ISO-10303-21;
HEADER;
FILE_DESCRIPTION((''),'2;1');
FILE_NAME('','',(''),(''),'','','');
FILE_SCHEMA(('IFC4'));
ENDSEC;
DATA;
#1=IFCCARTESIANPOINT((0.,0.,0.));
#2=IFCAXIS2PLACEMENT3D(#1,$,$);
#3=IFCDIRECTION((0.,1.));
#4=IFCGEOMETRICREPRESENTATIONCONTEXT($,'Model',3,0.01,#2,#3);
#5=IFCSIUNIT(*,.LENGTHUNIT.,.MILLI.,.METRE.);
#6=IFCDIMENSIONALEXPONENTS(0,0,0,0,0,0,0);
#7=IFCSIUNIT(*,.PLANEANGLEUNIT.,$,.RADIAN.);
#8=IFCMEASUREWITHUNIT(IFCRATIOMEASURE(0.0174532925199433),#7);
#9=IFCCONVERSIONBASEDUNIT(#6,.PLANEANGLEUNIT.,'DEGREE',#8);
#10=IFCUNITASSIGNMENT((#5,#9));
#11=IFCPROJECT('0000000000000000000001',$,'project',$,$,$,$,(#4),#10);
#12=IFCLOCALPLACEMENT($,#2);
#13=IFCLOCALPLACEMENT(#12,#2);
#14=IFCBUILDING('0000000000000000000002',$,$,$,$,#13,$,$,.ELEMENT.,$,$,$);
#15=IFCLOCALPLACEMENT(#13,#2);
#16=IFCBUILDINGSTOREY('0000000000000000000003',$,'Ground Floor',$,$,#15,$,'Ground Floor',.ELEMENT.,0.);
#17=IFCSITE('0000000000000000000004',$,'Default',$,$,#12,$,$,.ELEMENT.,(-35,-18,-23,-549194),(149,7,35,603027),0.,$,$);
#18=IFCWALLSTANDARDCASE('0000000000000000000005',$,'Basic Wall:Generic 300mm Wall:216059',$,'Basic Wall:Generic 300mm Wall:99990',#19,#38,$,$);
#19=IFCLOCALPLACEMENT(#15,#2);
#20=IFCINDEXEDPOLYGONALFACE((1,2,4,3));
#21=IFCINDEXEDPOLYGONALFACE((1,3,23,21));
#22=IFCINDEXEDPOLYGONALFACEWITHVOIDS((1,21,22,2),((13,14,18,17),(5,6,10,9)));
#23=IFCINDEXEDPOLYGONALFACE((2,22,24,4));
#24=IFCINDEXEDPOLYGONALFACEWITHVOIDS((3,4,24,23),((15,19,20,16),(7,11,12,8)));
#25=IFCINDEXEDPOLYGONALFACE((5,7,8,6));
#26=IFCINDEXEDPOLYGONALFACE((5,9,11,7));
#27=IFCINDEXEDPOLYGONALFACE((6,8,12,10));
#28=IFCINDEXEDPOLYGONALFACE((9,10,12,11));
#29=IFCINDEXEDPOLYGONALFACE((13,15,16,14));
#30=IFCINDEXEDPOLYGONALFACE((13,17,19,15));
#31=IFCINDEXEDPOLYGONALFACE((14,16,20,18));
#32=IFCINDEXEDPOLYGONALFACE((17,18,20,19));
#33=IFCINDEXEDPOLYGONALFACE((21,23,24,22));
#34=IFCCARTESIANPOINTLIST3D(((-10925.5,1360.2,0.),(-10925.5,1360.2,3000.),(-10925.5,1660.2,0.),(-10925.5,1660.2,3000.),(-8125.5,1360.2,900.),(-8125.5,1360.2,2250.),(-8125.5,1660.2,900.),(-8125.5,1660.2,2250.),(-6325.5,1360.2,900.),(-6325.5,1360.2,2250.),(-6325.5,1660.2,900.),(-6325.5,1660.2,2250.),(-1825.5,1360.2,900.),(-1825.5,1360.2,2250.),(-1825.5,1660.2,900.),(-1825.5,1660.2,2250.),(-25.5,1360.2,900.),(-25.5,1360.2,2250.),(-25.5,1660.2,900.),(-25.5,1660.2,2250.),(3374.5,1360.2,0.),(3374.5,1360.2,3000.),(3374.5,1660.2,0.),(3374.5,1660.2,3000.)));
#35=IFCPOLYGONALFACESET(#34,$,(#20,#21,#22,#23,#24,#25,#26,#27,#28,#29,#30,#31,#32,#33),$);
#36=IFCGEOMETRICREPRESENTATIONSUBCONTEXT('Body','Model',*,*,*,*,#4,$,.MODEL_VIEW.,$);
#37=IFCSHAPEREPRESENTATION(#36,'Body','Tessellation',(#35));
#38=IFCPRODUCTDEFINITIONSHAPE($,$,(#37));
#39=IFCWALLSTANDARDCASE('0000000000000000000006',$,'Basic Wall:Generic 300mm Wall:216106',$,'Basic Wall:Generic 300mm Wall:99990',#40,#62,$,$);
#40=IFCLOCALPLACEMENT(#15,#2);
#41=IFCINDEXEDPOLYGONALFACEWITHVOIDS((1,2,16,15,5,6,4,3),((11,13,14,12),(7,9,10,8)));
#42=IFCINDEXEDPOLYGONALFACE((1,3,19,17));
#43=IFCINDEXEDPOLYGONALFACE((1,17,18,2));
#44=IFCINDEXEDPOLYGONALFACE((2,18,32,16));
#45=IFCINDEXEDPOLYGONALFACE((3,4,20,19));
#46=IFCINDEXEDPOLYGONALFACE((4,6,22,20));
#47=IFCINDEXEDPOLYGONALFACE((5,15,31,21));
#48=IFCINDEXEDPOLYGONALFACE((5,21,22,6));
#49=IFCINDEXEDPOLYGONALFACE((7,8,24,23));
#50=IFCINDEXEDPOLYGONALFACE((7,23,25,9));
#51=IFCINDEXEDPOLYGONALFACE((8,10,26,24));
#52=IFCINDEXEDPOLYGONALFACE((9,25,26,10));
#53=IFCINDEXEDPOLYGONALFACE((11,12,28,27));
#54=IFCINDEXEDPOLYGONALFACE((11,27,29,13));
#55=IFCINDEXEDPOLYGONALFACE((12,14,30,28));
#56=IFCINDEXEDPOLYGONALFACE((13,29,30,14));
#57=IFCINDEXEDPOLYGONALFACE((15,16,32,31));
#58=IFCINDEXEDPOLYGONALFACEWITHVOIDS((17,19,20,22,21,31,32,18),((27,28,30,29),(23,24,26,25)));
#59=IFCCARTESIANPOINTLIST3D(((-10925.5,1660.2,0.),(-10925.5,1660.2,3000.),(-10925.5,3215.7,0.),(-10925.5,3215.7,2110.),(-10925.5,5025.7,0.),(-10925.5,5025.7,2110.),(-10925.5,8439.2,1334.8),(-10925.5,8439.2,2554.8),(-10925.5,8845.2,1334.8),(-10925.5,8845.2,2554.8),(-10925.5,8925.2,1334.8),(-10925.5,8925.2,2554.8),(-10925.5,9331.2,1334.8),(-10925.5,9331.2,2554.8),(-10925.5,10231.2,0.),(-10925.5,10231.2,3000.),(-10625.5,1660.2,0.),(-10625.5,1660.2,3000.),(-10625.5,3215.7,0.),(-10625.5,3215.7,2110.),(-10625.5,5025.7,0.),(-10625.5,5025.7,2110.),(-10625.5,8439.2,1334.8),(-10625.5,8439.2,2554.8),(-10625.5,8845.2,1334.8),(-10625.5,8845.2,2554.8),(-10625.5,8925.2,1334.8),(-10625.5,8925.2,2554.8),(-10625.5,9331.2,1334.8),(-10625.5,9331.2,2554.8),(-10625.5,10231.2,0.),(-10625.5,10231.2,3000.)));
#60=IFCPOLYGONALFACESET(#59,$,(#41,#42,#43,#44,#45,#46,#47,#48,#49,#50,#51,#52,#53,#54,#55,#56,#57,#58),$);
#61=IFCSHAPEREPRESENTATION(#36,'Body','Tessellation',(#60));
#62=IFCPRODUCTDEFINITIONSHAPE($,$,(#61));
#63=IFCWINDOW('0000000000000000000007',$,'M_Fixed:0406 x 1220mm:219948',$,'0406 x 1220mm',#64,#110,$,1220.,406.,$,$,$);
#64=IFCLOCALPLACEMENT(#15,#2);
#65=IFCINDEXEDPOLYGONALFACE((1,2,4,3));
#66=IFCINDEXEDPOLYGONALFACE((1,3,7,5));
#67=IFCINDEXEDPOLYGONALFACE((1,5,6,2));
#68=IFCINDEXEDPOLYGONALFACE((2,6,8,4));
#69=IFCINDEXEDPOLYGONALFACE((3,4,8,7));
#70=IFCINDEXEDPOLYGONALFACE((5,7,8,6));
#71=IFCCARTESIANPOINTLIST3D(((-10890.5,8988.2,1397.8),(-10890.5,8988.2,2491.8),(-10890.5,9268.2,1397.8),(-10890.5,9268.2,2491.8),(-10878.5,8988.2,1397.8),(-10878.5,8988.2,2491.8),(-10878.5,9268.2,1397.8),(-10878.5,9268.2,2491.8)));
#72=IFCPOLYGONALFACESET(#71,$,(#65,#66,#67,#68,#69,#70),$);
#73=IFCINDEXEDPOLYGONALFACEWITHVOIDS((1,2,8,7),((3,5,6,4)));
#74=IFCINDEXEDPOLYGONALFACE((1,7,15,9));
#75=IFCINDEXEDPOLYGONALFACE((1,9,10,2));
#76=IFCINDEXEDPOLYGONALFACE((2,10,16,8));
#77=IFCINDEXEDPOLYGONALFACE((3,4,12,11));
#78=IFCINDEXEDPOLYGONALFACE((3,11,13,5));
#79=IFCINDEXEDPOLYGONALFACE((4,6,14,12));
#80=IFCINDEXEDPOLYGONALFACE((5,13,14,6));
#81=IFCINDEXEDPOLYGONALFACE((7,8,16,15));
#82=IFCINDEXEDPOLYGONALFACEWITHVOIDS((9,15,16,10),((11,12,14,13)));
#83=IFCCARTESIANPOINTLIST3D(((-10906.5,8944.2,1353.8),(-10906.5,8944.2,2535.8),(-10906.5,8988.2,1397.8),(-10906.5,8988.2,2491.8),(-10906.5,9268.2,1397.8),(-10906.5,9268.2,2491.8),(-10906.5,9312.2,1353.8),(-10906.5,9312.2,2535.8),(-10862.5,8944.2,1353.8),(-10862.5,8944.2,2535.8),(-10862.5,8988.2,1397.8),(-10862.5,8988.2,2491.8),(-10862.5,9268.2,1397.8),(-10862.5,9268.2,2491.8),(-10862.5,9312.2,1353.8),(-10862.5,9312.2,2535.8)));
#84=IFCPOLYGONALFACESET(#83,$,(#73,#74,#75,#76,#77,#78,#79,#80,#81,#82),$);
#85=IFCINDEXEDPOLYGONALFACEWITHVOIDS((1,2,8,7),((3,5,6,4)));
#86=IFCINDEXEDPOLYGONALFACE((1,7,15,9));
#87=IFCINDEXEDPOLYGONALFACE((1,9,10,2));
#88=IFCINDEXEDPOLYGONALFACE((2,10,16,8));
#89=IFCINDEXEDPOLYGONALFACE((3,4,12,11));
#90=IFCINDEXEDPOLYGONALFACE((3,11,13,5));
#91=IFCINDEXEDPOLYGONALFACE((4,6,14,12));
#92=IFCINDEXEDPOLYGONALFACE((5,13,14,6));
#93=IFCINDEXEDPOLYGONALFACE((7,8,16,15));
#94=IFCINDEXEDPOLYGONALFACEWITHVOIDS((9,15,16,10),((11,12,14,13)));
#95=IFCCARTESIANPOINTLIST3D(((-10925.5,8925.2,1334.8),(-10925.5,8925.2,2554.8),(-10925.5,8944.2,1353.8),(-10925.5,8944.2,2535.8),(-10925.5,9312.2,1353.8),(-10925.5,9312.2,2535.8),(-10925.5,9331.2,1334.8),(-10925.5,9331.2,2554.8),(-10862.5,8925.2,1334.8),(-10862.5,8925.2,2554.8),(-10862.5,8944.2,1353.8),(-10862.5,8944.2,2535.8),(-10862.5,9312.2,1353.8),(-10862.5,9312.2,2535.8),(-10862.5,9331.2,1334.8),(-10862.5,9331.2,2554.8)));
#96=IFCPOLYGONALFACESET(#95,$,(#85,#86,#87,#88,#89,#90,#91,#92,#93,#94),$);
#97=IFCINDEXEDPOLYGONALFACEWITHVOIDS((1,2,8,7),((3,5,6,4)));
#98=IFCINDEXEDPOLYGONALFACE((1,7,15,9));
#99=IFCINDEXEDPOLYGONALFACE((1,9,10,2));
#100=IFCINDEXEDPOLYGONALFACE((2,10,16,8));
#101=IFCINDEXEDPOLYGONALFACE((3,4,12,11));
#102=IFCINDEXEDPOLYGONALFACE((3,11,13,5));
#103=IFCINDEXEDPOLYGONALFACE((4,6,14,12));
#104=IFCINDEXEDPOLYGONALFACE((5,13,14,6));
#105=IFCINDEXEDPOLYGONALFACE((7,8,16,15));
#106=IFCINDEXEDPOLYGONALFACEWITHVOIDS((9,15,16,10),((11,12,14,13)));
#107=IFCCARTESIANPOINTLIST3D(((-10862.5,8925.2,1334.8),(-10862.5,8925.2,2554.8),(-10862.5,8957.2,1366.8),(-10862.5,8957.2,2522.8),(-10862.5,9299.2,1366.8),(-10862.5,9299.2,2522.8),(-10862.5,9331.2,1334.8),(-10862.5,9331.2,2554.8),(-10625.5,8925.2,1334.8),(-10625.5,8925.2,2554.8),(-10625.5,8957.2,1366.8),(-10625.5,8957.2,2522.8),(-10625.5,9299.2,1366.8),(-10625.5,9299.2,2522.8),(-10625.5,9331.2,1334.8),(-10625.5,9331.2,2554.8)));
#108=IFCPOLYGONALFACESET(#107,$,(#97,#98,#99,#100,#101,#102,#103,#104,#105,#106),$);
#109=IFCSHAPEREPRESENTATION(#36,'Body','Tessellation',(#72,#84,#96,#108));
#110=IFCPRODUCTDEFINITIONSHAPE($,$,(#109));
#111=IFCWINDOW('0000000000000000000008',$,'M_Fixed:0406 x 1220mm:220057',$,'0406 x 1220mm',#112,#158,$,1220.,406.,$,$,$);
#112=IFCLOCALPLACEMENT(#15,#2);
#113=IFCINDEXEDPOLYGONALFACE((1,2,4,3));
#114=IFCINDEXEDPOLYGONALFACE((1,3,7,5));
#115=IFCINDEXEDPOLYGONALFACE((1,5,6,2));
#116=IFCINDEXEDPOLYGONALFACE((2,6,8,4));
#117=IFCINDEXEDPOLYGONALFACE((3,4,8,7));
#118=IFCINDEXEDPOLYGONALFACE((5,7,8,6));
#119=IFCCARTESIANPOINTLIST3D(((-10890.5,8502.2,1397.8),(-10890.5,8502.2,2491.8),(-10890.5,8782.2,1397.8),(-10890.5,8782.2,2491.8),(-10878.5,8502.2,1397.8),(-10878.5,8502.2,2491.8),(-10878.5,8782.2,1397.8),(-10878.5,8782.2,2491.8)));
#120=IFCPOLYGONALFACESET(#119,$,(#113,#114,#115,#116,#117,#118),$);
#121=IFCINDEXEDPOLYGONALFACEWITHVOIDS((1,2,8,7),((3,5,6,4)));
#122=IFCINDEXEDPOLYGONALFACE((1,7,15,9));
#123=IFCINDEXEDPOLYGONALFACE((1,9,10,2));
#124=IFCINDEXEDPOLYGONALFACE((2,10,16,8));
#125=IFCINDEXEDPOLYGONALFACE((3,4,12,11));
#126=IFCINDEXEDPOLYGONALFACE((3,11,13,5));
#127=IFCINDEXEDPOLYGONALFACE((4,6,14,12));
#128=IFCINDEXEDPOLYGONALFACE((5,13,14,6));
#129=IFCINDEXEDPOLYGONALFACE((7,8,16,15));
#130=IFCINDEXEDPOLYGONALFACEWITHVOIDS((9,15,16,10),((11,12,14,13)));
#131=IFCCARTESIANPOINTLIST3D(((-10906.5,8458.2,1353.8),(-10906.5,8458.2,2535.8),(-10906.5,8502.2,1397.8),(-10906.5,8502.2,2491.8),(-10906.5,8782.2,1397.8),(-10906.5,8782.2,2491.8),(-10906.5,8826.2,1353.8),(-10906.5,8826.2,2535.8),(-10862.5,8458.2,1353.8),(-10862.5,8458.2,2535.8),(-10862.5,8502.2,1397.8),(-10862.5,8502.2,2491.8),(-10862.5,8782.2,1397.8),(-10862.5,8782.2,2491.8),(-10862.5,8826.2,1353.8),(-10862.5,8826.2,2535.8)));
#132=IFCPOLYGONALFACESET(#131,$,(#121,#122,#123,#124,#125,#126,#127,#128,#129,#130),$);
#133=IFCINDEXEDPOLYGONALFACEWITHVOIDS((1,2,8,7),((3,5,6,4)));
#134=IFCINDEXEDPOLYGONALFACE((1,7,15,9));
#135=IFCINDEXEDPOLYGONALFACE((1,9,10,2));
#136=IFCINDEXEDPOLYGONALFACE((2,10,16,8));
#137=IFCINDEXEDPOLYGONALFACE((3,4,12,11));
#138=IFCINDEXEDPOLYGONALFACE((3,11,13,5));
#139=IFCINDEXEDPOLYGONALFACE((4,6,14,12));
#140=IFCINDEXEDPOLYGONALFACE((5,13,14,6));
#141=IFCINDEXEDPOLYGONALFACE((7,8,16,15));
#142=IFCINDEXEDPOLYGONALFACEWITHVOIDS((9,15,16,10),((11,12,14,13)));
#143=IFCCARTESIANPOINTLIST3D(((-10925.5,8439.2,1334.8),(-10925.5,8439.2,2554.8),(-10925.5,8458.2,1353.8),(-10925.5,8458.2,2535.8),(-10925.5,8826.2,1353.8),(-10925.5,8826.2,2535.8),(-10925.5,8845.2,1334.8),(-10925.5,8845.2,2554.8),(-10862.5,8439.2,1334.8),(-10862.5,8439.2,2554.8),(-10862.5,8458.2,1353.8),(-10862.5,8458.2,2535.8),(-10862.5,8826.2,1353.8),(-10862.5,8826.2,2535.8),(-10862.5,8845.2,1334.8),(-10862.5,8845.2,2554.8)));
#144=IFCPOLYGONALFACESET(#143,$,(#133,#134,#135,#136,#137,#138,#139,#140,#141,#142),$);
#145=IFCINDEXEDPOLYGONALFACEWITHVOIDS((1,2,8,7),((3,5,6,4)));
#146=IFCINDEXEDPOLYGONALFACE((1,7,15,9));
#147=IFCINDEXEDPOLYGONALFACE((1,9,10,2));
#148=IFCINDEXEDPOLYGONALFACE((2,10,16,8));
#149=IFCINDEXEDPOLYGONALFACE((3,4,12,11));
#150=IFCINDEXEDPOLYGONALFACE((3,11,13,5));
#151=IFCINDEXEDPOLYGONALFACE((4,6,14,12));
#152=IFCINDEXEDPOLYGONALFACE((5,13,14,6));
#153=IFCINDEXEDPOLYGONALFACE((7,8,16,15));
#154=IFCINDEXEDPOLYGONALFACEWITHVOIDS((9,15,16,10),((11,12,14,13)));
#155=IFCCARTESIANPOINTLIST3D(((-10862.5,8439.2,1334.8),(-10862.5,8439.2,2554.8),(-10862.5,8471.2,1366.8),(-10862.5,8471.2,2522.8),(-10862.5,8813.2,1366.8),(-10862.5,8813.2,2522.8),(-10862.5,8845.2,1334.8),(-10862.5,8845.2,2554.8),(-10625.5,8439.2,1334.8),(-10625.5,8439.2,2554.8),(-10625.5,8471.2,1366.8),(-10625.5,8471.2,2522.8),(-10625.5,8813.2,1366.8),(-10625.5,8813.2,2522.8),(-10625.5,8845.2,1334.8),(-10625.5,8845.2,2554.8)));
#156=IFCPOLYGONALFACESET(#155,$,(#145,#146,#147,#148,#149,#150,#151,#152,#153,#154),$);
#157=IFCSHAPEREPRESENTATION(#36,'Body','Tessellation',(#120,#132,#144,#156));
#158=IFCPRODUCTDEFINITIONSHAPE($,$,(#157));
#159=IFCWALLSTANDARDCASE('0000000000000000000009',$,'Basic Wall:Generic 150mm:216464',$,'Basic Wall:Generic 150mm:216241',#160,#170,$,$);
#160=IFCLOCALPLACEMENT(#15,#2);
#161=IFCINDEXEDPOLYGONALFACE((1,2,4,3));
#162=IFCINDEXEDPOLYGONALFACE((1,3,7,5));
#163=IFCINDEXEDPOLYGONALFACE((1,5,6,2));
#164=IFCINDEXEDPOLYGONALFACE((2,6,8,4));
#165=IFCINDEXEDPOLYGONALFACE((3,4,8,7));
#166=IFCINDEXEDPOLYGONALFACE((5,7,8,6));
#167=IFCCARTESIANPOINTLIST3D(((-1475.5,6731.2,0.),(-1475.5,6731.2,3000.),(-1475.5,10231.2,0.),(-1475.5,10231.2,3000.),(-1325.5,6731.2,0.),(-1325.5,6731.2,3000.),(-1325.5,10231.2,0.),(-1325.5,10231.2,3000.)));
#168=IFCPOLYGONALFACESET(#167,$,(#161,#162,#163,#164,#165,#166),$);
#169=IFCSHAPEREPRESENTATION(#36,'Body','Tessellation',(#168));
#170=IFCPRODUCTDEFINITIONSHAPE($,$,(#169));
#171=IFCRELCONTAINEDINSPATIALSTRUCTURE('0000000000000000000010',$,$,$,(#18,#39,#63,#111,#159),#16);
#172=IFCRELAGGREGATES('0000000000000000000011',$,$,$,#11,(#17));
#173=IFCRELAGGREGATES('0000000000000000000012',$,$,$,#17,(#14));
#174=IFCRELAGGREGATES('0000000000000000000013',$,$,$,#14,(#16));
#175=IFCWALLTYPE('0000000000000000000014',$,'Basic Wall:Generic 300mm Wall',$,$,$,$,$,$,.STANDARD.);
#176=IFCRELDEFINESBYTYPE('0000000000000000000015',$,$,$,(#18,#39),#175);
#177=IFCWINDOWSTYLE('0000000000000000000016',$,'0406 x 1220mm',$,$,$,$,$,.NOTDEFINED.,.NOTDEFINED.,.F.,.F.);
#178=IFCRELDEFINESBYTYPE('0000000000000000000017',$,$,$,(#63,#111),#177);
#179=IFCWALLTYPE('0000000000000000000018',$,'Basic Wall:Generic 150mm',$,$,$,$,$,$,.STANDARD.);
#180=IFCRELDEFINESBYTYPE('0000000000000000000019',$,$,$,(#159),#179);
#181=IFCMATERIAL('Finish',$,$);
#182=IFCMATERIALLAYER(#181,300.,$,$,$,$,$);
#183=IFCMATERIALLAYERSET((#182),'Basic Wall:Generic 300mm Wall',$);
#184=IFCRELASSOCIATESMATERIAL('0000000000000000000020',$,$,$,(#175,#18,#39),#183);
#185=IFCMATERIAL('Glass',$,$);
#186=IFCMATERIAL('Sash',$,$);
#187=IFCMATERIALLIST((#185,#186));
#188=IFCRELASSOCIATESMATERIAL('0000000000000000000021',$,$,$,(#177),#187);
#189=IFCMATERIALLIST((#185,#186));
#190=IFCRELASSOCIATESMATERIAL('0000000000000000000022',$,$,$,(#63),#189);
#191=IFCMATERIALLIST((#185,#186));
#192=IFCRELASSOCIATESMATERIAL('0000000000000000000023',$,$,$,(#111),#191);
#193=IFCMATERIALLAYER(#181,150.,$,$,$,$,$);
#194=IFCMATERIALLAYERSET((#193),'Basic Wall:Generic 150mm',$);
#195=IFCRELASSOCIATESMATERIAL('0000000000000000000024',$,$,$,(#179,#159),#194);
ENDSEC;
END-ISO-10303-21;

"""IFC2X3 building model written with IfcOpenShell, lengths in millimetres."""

from ifc_helpers import new_model, entity, si_unit, converted_unit, direction, frame, frame_2d, origin, place, context, subcontext, project, spatial, polyline, rectangle, outline, extrude, source, transform, mapped, material, material_list, layer, layer_set, layer_usage, type_object, type_shapes, element, fill, save


model = new_model("IFC2X3")

# Units and contexts
model_context = context("Model", 3, precision=0.01, world=origin(), true_north=direction((0.0, 1.0)))
body_context = subcontext(model_context, "Body", "Model", "MODEL_VIEW")
ifc_project = project(units=[si_unit("LENGTHUNIT", "METRE", prefix="MILLI"), converted_unit("PLANEANGLEUNIT", "DEGREE", entity("IfcRatioMeasure", 0.0174532925199433), si_unit("PLANEANGLEUNIT", "RADIAN"), dimensions=[0, 0, 0, 0, 0, 0, 0])], contexts=[model_context])

# Site, building, storey
site_placement = place(None, origin())
site = spatial("IfcSite", under=ifc_project, at=site_placement, Name="Default", CompositionType="ELEMENT", RefLatitude=(-35, -18, -23, -549194), RefLongitude=(149, 7, 35, 603027), RefElevation=0.0)
building_placement = place(site_placement, origin())
building = spatial("IfcBuilding", under=site, at=building_placement, CompositionType="ELEMENT")
storey_placement = place(building_placement, origin())
storey = spatial("IfcBuildingStorey", under=building, at=storey_placement, Name="Ground Floor", LongName="Ground Floor", CompositionType="ELEMENT", Elevation=0.0)

# Shared definitions
ifc_material_1 = material(Name="Finish")
ifc_layer_1 = layer(ifc_material_1, 300.0)
ifc_layer_set_1 = layer_set([ifc_layer_1], Name="Basic Wall:Generic 300mm Wall")
wall_type_1 = type_object("IfcWallType", Name="Basic Wall:Generic 300mm Wall", PredefinedType="STANDARD", material=ifc_layer_set_1)
ifc_material_2 = material(Name="Glass")
ifc_material_3 = material(Name="Sash")

# Wall, openings
ifc_layer_usage_1 = layer_usage(ifc_layer_set_1, "AXIS2", "NEGATIVE", 150.0)
wall_1_placement = place(storey_placement, frame((3374.5, 1510.2, 0.0), z_axis=(0.0, 0.0, 1.0), x_axis=(-1.0, 0.0, 0.0)))
wall_1 = element("IfcWallStandardCase", 1, at=wall_1_placement, inside=storey, type_object=wall_type_1, material=ifc_layer_usage_1, Name="Basic Wall:Generic 300mm Wall:216059", ObjectType="Basic Wall:Generic 300mm Wall:99990", context=body_context, shape_type="SweptSolid", body=[
    extrude(rectangle(XDim=14300.0, YDim=300.0, at=frame_2d((7150.0, 0.0), x_axis=(-1.0, 0.0))), origin(), (0.0, 0.0, 1.0), 3000.0),
])
opening_1_placement = place(wall_1_placement, frame((5200.0, 150.0, 900.0)))
element("IfcOpeningElement", 2, at=opening_1_placement, cuts=wall_1, ObjectType="Opening", context=body_context, shape_type="SweptSolid", body=[
    extrude(rectangle(XDim=1350.0, YDim=1800.0, at=frame_2d((675.0, 900.0), x_axis=(-1.0, 0.0))), frame((0.0, 0.0, 0.0), z_axis=(0.0, -1.0, 0.0), x_axis=(0.0, 0.0, 1.0)), (0.0, 0.0, 1.0), 300.0),
])
opening_2_placement = place(wall_1_placement, frame((11500.0, 150.0, 900.0)))
element("IfcOpeningElement", 3, at=opening_2_placement, cuts=wall_1, ObjectType="Opening", context=body_context, shape_type="SweptSolid", body=[
    extrude(rectangle(XDim=1350.0, YDim=1800.0, at=frame_2d((675.0, 900.0), x_axis=(-1.0, 0.0))), frame((0.0, 0.0, 0.0), z_axis=(0.0, -1.0, 0.0), x_axis=(0.0, 0.0, 1.0)), (0.0, 0.0, 1.0), 300.0),
])

# Wall, openings, windows
ifc_layer_usage_2 = layer_usage(ifc_layer_set_1, "AXIS2", "NEGATIVE", 150.0)
wall_2_placement = place(storey_placement, frame((-10775.5, 1660.2, 0.0), z_axis=(0.0, 0.0, 1.0), x_axis=(0.0, 1.0, 0.0)))
wall_2 = element("IfcWallStandardCase", 4, at=wall_2_placement, inside=storey, type_object=wall_type_1, material=ifc_layer_usage_2, Name="Basic Wall:Generic 300mm Wall:216106", ObjectType="Basic Wall:Generic 300mm Wall:99990", context=body_context, shape_type="SweptSolid", body=[
    extrude(rectangle(XDim=8571.0, YDim=300.0, at=frame_2d((4285.5, 0.0), x_axis=(-1.0, 0.0))), origin(), (0.0, 0.0, 1.0), 3000.0),
])
opening_3_placement = place(wall_2_placement, frame((1555.5, -150.0, 0.0)))
element("IfcOpeningElement", 5, at=opening_3_placement, cuts=wall_2, ObjectType="Opening", context=body_context, shape_type="SweptSolid", body=[
    extrude(rectangle(XDim=2110.0, YDim=1810.0, at=frame_2d((1055.0, 905.0), x_axis=(1.0, 0.0))), frame((0.0, 0.0, 0.0), z_axis=(0.0, 1.0, 0.0), x_axis=(0.0, 0.0, 1.0)), (0.0, 0.0, 1.0), 300.0),
])
opening_4_placement = place(wall_2_placement, frame((7265.0, -150.0, 1334.8)))
opening_4 = element("IfcOpeningElement", 6, at=opening_4_placement, cuts=wall_2, ObjectType="Opening", context=body_context, shape_type="SweptSolid", body=[
    extrude(rectangle(XDim=1220.0, YDim=406.0, at=frame_2d((610.0, 203.0), x_axis=(1.0, 0.0))), frame((0.0, 0.0, 0.0), z_axis=(0.0, 1.0, 0.0), x_axis=(0.0, 0.0, 1.0)), (0.0, 0.0, 1.0), 300.0),
])
opening_5_placement = place(wall_2_placement, frame((6779.0, -150.0, 1334.8)))
opening_5 = element("IfcOpeningElement", 7, at=opening_5_placement, cuts=wall_2, ObjectType="Opening", context=body_context, shape_type="SweptSolid", body=[
    extrude(rectangle(XDim=1220.0, YDim=406.0, at=frame_2d((610.0, 203.0), x_axis=(1.0, 0.0))), frame((0.0, 0.0, 0.0), z_axis=(0.0, 1.0, 0.0), x_axis=(0.0, 0.0, 1.0)), (0.0, 0.0, 1.0), 300.0),
])
ifc_material_list_1 = material_list([ifc_material_2, ifc_material_3])
ifc_material_list_2 = material_list([ifc_material_2, ifc_material_3])
window_style_1 = type_object("IfcWindowStyle", Name="0406 x 1220mm", ConstructionType="NOTDEFINED", OperationType="NOTDEFINED", ParameterTakesPrecedence=False, Sizeable=False, material=ifc_material_list_2)
shared_shape_1 = source(origin(), body_context, "Body", "SweptSolid", [
    extrude(rectangle(XDim=12.0, YDim=280.0, at=frame_2d((0.0, 0.0), x_axis=(1.0, 0.0))), frame((203.0, 259.0, 63.0), z_axis=(0.0, 0.0, 1.0), x_axis=(0.0, -1.0, 0.0)), (0.0, 0.0, 1.0), 1094.0),
    extrude(outline(polyline([(-184.0, -591.0), (184.0, -591.0), (184.0, 591.0), (-184.0, 591.0), (-184.0, -591.0)]), holes=[polyline([(-140.0, -547.0), (-140.0, 547.0), (140.0, 547.0), (140.0, -547.0), (-140.0, -547.0)])]), frame((203.0, 237.0, 610.0), z_axis=(0.0, 1.0, 0.0), x_axis=(1.0, 0.0, 0.0)), (0.0, 0.0, 1.0), 44.0),
    extrude(outline(polyline([(-203.0, -610.0), (203.0, -610.0), (203.0, 610.0), (-203.0, 610.0), (-203.0, -610.0)]), holes=[polyline([(-184.0, -591.0), (-184.0, 591.0), (184.0, 591.0), (184.0, -591.0), (-184.0, -591.0)])]), frame((203.0, 237.0, 610.0), z_axis=(0.0, 1.0, 0.0), x_axis=(1.0, 0.0, 0.0)), (0.0, 0.0, 1.0), 63.0),
    extrude(outline(polyline([(-203.0, -610.0), (203.0, -610.0), (203.0, 610.0), (-203.0, 610.0), (-203.0, -610.0)]), holes=[polyline([(-171.0, -578.0), (-171.0, 578.0), (171.0, 578.0), (171.0, -578.0), (-171.0, -578.0)])]), frame((203.0, 0.0, 610.0), z_axis=(0.0, 1.0, 0.0), x_axis=(1.0, 0.0, 0.0)), (0.0, 0.0, 1.0), 237.0),
])
type_shapes(window_style_1, [shared_shape_1])
window_1_placement = place(opening_4_placement, origin())
window_1 = element("IfcWindow", 8, at=window_1_placement, inside=storey, type_object=window_style_1, material=ifc_material_list_1, Name="M_Fixed:0406 x 1220mm:219948", ObjectType="0406 x 1220mm", OverallHeight=1220.0, OverallWidth=406.0, context=body_context, shape_type="MappedRepresentation", body=[
    mapped(shared_shape_1, transform((0.0, 0.0, 0.0), scale=1.0)),
])
fill(opening_4, window_1)
ifc_material_list_3 = material_list([ifc_material_2, ifc_material_3])
window_2_placement = place(opening_5_placement, origin())
window_2 = element("IfcWindow", 9, at=window_2_placement, inside=storey, type_object=window_style_1, material=ifc_material_list_3, Name="M_Fixed:0406 x 1220mm:220057", ObjectType="0406 x 1220mm", OverallHeight=1220.0, OverallWidth=406.0, context=body_context, shape_type="MappedRepresentation", body=[
    mapped(shared_shape_1, transform((0.0, 0.0, 0.0), scale=1.0)),
])
fill(opening_5, window_2)

# Wall
ifc_layer_2 = layer(ifc_material_1, 150.0)
ifc_layer_set_2 = layer_set([ifc_layer_2], Name="Basic Wall:Generic 150mm")
ifc_layer_usage_3 = layer_usage(ifc_layer_set_2, "AXIS2", "NEGATIVE", 75.0)
wall_type_2 = type_object("IfcWallType", Name="Basic Wall:Generic 150mm", PredefinedType="STANDARD", material=ifc_layer_set_2)
wall_3_placement = place(storey_placement, frame((-1400.5, 10231.2, 0.0), z_axis=(0.0, 0.0, 1.0), x_axis=(0.0, -1.0, 0.0)))
element("IfcWallStandardCase", 10, at=wall_3_placement, inside=storey, type_object=wall_type_2, material=ifc_layer_usage_3, Name="Basic Wall:Generic 150mm:216464", ObjectType="Basic Wall:Generic 150mm:216241", context=body_context, shape_type="SweptSolid", body=[
    extrude(rectangle(XDim=3500.0, YDim=150.0, at=frame_2d((1750.0, 0.0), x_axis=(-1.0, 0.0))), origin(), (0.0, 0.0, 1.0), 3000.0),
])

save(model, "model.ifc")
